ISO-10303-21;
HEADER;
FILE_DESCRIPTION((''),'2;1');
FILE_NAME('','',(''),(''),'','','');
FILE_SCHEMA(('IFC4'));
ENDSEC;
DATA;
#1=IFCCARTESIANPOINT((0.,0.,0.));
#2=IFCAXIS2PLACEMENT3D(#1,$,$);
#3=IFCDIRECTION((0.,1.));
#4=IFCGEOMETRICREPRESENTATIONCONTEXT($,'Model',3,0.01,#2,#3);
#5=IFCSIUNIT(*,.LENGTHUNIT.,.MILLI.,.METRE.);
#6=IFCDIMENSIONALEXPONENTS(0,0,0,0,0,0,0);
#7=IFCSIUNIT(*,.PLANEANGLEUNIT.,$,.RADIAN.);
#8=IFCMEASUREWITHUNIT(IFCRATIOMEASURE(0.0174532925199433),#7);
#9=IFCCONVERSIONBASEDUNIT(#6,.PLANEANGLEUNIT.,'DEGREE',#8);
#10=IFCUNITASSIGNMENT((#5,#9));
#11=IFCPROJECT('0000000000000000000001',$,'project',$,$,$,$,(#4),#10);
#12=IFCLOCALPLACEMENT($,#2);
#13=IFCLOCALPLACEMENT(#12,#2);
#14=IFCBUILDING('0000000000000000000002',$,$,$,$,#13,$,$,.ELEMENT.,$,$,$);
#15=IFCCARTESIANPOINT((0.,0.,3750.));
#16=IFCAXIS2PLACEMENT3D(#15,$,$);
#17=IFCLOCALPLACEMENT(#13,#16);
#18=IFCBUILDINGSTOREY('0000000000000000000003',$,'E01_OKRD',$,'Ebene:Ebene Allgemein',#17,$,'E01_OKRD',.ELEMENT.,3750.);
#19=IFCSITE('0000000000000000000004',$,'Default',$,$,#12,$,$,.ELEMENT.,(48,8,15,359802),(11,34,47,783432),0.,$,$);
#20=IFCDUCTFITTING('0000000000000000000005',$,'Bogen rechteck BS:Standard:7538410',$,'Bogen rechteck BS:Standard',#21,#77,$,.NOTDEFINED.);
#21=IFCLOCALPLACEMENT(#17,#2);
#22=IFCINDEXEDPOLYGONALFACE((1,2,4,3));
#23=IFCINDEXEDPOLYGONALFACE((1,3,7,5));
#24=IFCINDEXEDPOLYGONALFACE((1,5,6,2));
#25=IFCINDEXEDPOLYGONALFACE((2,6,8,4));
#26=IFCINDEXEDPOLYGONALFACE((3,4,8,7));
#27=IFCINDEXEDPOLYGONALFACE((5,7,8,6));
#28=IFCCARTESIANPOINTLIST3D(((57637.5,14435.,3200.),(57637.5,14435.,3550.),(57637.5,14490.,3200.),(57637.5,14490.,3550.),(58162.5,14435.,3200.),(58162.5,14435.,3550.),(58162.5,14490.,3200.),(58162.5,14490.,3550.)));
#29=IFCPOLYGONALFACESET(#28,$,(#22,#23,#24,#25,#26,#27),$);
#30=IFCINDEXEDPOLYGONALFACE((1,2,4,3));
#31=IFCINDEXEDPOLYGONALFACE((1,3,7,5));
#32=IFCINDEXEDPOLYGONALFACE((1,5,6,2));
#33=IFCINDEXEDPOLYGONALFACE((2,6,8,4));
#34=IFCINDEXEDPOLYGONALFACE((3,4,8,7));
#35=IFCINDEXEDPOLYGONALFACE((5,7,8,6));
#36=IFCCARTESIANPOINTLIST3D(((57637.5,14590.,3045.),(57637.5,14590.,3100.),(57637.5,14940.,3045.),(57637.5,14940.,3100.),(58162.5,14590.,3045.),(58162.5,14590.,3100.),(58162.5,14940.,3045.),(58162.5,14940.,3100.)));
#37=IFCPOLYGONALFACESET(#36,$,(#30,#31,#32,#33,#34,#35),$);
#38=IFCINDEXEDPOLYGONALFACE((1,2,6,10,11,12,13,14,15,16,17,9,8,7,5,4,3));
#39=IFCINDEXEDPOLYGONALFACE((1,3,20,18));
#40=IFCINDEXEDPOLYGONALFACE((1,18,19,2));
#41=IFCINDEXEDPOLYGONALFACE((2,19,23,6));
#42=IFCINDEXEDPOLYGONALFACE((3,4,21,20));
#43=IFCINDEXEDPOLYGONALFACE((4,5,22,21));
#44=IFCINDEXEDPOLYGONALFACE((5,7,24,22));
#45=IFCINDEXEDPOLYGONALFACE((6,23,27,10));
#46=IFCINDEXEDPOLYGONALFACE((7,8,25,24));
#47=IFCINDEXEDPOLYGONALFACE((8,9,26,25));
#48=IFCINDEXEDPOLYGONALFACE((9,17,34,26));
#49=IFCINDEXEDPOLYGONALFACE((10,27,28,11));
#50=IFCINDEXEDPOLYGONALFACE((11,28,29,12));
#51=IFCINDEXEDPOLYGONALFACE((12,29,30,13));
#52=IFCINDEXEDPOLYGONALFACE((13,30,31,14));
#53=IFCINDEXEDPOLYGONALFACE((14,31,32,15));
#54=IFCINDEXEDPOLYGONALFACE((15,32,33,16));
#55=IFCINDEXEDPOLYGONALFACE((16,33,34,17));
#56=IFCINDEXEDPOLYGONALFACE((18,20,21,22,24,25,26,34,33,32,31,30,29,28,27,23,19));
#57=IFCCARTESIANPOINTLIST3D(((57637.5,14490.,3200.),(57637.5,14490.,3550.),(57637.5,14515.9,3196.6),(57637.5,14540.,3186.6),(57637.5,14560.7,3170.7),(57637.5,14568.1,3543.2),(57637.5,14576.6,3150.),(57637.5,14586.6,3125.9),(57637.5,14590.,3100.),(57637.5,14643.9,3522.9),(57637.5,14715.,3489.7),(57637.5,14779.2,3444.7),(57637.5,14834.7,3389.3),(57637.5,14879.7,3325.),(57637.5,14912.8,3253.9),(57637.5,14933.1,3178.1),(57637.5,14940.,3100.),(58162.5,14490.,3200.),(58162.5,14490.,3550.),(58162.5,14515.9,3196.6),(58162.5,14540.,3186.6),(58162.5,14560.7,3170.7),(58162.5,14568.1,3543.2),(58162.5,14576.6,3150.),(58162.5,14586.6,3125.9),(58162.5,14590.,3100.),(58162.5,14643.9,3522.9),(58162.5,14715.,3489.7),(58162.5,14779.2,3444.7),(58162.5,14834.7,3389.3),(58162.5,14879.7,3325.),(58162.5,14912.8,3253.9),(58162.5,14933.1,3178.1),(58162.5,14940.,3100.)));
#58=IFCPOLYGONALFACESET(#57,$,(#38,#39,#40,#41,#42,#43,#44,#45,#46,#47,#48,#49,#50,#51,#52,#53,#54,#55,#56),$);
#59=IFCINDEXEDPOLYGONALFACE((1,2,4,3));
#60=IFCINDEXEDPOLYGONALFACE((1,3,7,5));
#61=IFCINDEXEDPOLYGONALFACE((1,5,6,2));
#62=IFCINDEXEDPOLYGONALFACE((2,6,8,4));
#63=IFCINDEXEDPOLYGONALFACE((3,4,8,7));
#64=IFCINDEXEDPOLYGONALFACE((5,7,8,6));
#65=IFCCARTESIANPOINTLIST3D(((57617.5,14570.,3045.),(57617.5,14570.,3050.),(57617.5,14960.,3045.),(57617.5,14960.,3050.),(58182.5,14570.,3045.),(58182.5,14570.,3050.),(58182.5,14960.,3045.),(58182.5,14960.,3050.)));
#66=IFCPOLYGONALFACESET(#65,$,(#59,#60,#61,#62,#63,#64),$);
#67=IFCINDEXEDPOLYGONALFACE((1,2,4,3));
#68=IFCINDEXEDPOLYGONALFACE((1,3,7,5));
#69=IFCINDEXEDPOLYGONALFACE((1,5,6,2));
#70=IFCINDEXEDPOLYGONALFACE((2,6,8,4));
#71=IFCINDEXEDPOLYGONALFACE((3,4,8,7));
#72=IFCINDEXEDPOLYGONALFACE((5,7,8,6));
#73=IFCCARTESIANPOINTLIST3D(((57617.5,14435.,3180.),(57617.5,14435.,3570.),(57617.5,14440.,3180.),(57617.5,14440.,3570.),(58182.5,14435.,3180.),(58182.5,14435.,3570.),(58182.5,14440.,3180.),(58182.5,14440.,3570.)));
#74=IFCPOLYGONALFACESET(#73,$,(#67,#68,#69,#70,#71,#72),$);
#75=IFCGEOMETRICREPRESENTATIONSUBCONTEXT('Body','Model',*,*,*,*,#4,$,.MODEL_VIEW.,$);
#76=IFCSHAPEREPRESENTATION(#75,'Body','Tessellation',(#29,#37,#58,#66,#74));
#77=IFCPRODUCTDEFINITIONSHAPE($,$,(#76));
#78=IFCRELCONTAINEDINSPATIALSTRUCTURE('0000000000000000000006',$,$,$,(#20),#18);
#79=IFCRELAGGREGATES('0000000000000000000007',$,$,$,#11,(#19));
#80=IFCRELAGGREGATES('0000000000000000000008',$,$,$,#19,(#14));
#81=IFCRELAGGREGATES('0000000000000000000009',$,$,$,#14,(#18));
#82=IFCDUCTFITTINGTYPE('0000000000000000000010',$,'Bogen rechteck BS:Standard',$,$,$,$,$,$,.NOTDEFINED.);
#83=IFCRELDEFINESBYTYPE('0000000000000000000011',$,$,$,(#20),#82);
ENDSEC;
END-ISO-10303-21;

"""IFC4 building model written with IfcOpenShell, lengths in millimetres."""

from ifc_helpers import new_model, entity, si_unit, converted_unit, direction, frame, frame_2d, origin, origin_2d_with_axis, place, context, subcontext, project, spatial, polyline, circle_curve, parameter, trimmed, segment, composite_curve, rectangle, outline, extrude, source, transform, mapped, type_object, type_shapes, element, save


model = new_model("IFC4")

# Units and contexts
model_context = context("Model", 3, precision=0.01, world=origin(), true_north=direction((0.0, 1.0)))
body_context = subcontext(model_context, "Body", "Model", "MODEL_VIEW")
ifc_project = project(units=[si_unit("LENGTHUNIT", "METRE", prefix="MILLI"), converted_unit("PLANEANGLEUNIT", "DEGREE", entity("IfcRatioMeasure", 0.0174532925199433), si_unit("PLANEANGLEUNIT", "RADIAN"), dimensions=[0, 0, 0, 0, 0, 0, 0])], contexts=[model_context])

# Site, building, storey
site_placement = place(None, origin())
site = spatial("IfcSite", under=ifc_project, at=site_placement, Name="Default", CompositionType="ELEMENT", RefLatitude=(48, 8, 15, 359802), RefLongitude=(11, 34, 47, 783432), RefElevation=0.0)
building_placement = place(site_placement, origin())
building = spatial("IfcBuilding", under=site, at=building_placement, CompositionType="ELEMENT")
storey_placement = place(building_placement, frame((0.0, 0.0, 3750.0)))
storey = spatial("IfcBuildingStorey", under=building, at=storey_placement, Name="E01_OKRD", ObjectType="Ebene:Ebene Allgemein", LongName="E01_OKRD", CompositionType="ELEMENT", Elevation=3750.0)

# Duct fitting
duct_fitting_type_1 = type_object("IfcDuctFittingType", Name="Bogen rechteck BS:Standard", PredefinedType="NOTDEFINED")
shared_shape_1 = source(origin(), body_context, "Body", "SweptSolid", [
    extrude(rectangle(XDim=55.0, YDim=350.0, at=origin_2d_with_axis()), frame((0.0, 302.5, -262.5), z_axis=(0.0, 0.0, 1.0), x_axis=(0.0, 1.0, 0.0)), (0.0, 0.0, 1.0), 525.0),
    extrude(rectangle(XDim=350.0, YDim=55.0, at=frame_2d((0.0, 0.0), x_axis=(1.0, 0.0))), frame((-302.5, 0.0, -262.5), z_axis=(0.0, 0.0, 1.0), x_axis=(0.0, -1.0, 0.0)), (0.0, 0.0, 1.0), 525.0),
    extrude(outline(composite_curve([segment(polyline([(-312.5, -137.5), (37.5, -137.5)]), True, "CONTINUOUS"), segment(trimmed(circle_curve(frame_2d((137.5, -137.5), x_axis=(0.0, 1.0)), 100.0), [parameter(0.0)], [parameter(90.0)], True, "PARAMETER"), False, "CONTINUOUS"), segment(polyline([(137.5, -37.5), (137.5, 312.5)]), True, "CONTINUOUS"), segment(trimmed(circle_curve(frame_2d((137.5, -137.5), x_axis=(0.0, 1.0)), 450.0), [parameter(0.0)], [parameter(90.0)], True, "PARAMETER"), True, "CONTINUOUS")], self_intersect=False)), frame((-137.5, 137.5, -262.5), z_axis=(0.0, 0.0, 1.0), x_axis=(-1.0, 0.0, 0.0)), (0.0, 0.0, 1.0), 525.0),
    extrude(rectangle(XDim=5.0, YDim=390.0, at=frame_2d((0.0, 0.0), x_axis=(1.0, 0.0))), frame((-327.5, 0.0, -282.5)), (0.0, 0.0, 1.0), 565.0),
    extrude(rectangle(XDim=5.0, YDim=390.0, at=frame_2d((0.0, 0.0), x_axis=(1.0, 0.0))), frame((0.0, 327.5, -282.5), z_axis=(0.0, 0.0, 1.0), x_axis=(0.0, 1.0, 0.0)), (0.0, 0.0, 1.0), 565.0),
])
type_shapes(duct_fitting_type_1, [shared_shape_1])
duct_fitting_1_placement = place(storey_placement, frame((57900.0, 14765.0, 3375.0), z_axis=(1.0, 0.0, 0.0), x_axis=(0.0, 0.0, 1.0)))
element("IfcDuctFitting", 1, at=duct_fitting_1_placement, inside=storey, type_object=duct_fitting_type_1, Name="Bogen rechteck BS:Standard:7538410", ObjectType="Bogen rechteck BS:Standard", PredefinedType="NOTDEFINED", context=body_context, shape_type="MappedRepresentation", body=[
    mapped(shared_shape_1, transform((0.0, 0.0, 0.0), scale=1.0)),
])

save(model, "model.ifc")
